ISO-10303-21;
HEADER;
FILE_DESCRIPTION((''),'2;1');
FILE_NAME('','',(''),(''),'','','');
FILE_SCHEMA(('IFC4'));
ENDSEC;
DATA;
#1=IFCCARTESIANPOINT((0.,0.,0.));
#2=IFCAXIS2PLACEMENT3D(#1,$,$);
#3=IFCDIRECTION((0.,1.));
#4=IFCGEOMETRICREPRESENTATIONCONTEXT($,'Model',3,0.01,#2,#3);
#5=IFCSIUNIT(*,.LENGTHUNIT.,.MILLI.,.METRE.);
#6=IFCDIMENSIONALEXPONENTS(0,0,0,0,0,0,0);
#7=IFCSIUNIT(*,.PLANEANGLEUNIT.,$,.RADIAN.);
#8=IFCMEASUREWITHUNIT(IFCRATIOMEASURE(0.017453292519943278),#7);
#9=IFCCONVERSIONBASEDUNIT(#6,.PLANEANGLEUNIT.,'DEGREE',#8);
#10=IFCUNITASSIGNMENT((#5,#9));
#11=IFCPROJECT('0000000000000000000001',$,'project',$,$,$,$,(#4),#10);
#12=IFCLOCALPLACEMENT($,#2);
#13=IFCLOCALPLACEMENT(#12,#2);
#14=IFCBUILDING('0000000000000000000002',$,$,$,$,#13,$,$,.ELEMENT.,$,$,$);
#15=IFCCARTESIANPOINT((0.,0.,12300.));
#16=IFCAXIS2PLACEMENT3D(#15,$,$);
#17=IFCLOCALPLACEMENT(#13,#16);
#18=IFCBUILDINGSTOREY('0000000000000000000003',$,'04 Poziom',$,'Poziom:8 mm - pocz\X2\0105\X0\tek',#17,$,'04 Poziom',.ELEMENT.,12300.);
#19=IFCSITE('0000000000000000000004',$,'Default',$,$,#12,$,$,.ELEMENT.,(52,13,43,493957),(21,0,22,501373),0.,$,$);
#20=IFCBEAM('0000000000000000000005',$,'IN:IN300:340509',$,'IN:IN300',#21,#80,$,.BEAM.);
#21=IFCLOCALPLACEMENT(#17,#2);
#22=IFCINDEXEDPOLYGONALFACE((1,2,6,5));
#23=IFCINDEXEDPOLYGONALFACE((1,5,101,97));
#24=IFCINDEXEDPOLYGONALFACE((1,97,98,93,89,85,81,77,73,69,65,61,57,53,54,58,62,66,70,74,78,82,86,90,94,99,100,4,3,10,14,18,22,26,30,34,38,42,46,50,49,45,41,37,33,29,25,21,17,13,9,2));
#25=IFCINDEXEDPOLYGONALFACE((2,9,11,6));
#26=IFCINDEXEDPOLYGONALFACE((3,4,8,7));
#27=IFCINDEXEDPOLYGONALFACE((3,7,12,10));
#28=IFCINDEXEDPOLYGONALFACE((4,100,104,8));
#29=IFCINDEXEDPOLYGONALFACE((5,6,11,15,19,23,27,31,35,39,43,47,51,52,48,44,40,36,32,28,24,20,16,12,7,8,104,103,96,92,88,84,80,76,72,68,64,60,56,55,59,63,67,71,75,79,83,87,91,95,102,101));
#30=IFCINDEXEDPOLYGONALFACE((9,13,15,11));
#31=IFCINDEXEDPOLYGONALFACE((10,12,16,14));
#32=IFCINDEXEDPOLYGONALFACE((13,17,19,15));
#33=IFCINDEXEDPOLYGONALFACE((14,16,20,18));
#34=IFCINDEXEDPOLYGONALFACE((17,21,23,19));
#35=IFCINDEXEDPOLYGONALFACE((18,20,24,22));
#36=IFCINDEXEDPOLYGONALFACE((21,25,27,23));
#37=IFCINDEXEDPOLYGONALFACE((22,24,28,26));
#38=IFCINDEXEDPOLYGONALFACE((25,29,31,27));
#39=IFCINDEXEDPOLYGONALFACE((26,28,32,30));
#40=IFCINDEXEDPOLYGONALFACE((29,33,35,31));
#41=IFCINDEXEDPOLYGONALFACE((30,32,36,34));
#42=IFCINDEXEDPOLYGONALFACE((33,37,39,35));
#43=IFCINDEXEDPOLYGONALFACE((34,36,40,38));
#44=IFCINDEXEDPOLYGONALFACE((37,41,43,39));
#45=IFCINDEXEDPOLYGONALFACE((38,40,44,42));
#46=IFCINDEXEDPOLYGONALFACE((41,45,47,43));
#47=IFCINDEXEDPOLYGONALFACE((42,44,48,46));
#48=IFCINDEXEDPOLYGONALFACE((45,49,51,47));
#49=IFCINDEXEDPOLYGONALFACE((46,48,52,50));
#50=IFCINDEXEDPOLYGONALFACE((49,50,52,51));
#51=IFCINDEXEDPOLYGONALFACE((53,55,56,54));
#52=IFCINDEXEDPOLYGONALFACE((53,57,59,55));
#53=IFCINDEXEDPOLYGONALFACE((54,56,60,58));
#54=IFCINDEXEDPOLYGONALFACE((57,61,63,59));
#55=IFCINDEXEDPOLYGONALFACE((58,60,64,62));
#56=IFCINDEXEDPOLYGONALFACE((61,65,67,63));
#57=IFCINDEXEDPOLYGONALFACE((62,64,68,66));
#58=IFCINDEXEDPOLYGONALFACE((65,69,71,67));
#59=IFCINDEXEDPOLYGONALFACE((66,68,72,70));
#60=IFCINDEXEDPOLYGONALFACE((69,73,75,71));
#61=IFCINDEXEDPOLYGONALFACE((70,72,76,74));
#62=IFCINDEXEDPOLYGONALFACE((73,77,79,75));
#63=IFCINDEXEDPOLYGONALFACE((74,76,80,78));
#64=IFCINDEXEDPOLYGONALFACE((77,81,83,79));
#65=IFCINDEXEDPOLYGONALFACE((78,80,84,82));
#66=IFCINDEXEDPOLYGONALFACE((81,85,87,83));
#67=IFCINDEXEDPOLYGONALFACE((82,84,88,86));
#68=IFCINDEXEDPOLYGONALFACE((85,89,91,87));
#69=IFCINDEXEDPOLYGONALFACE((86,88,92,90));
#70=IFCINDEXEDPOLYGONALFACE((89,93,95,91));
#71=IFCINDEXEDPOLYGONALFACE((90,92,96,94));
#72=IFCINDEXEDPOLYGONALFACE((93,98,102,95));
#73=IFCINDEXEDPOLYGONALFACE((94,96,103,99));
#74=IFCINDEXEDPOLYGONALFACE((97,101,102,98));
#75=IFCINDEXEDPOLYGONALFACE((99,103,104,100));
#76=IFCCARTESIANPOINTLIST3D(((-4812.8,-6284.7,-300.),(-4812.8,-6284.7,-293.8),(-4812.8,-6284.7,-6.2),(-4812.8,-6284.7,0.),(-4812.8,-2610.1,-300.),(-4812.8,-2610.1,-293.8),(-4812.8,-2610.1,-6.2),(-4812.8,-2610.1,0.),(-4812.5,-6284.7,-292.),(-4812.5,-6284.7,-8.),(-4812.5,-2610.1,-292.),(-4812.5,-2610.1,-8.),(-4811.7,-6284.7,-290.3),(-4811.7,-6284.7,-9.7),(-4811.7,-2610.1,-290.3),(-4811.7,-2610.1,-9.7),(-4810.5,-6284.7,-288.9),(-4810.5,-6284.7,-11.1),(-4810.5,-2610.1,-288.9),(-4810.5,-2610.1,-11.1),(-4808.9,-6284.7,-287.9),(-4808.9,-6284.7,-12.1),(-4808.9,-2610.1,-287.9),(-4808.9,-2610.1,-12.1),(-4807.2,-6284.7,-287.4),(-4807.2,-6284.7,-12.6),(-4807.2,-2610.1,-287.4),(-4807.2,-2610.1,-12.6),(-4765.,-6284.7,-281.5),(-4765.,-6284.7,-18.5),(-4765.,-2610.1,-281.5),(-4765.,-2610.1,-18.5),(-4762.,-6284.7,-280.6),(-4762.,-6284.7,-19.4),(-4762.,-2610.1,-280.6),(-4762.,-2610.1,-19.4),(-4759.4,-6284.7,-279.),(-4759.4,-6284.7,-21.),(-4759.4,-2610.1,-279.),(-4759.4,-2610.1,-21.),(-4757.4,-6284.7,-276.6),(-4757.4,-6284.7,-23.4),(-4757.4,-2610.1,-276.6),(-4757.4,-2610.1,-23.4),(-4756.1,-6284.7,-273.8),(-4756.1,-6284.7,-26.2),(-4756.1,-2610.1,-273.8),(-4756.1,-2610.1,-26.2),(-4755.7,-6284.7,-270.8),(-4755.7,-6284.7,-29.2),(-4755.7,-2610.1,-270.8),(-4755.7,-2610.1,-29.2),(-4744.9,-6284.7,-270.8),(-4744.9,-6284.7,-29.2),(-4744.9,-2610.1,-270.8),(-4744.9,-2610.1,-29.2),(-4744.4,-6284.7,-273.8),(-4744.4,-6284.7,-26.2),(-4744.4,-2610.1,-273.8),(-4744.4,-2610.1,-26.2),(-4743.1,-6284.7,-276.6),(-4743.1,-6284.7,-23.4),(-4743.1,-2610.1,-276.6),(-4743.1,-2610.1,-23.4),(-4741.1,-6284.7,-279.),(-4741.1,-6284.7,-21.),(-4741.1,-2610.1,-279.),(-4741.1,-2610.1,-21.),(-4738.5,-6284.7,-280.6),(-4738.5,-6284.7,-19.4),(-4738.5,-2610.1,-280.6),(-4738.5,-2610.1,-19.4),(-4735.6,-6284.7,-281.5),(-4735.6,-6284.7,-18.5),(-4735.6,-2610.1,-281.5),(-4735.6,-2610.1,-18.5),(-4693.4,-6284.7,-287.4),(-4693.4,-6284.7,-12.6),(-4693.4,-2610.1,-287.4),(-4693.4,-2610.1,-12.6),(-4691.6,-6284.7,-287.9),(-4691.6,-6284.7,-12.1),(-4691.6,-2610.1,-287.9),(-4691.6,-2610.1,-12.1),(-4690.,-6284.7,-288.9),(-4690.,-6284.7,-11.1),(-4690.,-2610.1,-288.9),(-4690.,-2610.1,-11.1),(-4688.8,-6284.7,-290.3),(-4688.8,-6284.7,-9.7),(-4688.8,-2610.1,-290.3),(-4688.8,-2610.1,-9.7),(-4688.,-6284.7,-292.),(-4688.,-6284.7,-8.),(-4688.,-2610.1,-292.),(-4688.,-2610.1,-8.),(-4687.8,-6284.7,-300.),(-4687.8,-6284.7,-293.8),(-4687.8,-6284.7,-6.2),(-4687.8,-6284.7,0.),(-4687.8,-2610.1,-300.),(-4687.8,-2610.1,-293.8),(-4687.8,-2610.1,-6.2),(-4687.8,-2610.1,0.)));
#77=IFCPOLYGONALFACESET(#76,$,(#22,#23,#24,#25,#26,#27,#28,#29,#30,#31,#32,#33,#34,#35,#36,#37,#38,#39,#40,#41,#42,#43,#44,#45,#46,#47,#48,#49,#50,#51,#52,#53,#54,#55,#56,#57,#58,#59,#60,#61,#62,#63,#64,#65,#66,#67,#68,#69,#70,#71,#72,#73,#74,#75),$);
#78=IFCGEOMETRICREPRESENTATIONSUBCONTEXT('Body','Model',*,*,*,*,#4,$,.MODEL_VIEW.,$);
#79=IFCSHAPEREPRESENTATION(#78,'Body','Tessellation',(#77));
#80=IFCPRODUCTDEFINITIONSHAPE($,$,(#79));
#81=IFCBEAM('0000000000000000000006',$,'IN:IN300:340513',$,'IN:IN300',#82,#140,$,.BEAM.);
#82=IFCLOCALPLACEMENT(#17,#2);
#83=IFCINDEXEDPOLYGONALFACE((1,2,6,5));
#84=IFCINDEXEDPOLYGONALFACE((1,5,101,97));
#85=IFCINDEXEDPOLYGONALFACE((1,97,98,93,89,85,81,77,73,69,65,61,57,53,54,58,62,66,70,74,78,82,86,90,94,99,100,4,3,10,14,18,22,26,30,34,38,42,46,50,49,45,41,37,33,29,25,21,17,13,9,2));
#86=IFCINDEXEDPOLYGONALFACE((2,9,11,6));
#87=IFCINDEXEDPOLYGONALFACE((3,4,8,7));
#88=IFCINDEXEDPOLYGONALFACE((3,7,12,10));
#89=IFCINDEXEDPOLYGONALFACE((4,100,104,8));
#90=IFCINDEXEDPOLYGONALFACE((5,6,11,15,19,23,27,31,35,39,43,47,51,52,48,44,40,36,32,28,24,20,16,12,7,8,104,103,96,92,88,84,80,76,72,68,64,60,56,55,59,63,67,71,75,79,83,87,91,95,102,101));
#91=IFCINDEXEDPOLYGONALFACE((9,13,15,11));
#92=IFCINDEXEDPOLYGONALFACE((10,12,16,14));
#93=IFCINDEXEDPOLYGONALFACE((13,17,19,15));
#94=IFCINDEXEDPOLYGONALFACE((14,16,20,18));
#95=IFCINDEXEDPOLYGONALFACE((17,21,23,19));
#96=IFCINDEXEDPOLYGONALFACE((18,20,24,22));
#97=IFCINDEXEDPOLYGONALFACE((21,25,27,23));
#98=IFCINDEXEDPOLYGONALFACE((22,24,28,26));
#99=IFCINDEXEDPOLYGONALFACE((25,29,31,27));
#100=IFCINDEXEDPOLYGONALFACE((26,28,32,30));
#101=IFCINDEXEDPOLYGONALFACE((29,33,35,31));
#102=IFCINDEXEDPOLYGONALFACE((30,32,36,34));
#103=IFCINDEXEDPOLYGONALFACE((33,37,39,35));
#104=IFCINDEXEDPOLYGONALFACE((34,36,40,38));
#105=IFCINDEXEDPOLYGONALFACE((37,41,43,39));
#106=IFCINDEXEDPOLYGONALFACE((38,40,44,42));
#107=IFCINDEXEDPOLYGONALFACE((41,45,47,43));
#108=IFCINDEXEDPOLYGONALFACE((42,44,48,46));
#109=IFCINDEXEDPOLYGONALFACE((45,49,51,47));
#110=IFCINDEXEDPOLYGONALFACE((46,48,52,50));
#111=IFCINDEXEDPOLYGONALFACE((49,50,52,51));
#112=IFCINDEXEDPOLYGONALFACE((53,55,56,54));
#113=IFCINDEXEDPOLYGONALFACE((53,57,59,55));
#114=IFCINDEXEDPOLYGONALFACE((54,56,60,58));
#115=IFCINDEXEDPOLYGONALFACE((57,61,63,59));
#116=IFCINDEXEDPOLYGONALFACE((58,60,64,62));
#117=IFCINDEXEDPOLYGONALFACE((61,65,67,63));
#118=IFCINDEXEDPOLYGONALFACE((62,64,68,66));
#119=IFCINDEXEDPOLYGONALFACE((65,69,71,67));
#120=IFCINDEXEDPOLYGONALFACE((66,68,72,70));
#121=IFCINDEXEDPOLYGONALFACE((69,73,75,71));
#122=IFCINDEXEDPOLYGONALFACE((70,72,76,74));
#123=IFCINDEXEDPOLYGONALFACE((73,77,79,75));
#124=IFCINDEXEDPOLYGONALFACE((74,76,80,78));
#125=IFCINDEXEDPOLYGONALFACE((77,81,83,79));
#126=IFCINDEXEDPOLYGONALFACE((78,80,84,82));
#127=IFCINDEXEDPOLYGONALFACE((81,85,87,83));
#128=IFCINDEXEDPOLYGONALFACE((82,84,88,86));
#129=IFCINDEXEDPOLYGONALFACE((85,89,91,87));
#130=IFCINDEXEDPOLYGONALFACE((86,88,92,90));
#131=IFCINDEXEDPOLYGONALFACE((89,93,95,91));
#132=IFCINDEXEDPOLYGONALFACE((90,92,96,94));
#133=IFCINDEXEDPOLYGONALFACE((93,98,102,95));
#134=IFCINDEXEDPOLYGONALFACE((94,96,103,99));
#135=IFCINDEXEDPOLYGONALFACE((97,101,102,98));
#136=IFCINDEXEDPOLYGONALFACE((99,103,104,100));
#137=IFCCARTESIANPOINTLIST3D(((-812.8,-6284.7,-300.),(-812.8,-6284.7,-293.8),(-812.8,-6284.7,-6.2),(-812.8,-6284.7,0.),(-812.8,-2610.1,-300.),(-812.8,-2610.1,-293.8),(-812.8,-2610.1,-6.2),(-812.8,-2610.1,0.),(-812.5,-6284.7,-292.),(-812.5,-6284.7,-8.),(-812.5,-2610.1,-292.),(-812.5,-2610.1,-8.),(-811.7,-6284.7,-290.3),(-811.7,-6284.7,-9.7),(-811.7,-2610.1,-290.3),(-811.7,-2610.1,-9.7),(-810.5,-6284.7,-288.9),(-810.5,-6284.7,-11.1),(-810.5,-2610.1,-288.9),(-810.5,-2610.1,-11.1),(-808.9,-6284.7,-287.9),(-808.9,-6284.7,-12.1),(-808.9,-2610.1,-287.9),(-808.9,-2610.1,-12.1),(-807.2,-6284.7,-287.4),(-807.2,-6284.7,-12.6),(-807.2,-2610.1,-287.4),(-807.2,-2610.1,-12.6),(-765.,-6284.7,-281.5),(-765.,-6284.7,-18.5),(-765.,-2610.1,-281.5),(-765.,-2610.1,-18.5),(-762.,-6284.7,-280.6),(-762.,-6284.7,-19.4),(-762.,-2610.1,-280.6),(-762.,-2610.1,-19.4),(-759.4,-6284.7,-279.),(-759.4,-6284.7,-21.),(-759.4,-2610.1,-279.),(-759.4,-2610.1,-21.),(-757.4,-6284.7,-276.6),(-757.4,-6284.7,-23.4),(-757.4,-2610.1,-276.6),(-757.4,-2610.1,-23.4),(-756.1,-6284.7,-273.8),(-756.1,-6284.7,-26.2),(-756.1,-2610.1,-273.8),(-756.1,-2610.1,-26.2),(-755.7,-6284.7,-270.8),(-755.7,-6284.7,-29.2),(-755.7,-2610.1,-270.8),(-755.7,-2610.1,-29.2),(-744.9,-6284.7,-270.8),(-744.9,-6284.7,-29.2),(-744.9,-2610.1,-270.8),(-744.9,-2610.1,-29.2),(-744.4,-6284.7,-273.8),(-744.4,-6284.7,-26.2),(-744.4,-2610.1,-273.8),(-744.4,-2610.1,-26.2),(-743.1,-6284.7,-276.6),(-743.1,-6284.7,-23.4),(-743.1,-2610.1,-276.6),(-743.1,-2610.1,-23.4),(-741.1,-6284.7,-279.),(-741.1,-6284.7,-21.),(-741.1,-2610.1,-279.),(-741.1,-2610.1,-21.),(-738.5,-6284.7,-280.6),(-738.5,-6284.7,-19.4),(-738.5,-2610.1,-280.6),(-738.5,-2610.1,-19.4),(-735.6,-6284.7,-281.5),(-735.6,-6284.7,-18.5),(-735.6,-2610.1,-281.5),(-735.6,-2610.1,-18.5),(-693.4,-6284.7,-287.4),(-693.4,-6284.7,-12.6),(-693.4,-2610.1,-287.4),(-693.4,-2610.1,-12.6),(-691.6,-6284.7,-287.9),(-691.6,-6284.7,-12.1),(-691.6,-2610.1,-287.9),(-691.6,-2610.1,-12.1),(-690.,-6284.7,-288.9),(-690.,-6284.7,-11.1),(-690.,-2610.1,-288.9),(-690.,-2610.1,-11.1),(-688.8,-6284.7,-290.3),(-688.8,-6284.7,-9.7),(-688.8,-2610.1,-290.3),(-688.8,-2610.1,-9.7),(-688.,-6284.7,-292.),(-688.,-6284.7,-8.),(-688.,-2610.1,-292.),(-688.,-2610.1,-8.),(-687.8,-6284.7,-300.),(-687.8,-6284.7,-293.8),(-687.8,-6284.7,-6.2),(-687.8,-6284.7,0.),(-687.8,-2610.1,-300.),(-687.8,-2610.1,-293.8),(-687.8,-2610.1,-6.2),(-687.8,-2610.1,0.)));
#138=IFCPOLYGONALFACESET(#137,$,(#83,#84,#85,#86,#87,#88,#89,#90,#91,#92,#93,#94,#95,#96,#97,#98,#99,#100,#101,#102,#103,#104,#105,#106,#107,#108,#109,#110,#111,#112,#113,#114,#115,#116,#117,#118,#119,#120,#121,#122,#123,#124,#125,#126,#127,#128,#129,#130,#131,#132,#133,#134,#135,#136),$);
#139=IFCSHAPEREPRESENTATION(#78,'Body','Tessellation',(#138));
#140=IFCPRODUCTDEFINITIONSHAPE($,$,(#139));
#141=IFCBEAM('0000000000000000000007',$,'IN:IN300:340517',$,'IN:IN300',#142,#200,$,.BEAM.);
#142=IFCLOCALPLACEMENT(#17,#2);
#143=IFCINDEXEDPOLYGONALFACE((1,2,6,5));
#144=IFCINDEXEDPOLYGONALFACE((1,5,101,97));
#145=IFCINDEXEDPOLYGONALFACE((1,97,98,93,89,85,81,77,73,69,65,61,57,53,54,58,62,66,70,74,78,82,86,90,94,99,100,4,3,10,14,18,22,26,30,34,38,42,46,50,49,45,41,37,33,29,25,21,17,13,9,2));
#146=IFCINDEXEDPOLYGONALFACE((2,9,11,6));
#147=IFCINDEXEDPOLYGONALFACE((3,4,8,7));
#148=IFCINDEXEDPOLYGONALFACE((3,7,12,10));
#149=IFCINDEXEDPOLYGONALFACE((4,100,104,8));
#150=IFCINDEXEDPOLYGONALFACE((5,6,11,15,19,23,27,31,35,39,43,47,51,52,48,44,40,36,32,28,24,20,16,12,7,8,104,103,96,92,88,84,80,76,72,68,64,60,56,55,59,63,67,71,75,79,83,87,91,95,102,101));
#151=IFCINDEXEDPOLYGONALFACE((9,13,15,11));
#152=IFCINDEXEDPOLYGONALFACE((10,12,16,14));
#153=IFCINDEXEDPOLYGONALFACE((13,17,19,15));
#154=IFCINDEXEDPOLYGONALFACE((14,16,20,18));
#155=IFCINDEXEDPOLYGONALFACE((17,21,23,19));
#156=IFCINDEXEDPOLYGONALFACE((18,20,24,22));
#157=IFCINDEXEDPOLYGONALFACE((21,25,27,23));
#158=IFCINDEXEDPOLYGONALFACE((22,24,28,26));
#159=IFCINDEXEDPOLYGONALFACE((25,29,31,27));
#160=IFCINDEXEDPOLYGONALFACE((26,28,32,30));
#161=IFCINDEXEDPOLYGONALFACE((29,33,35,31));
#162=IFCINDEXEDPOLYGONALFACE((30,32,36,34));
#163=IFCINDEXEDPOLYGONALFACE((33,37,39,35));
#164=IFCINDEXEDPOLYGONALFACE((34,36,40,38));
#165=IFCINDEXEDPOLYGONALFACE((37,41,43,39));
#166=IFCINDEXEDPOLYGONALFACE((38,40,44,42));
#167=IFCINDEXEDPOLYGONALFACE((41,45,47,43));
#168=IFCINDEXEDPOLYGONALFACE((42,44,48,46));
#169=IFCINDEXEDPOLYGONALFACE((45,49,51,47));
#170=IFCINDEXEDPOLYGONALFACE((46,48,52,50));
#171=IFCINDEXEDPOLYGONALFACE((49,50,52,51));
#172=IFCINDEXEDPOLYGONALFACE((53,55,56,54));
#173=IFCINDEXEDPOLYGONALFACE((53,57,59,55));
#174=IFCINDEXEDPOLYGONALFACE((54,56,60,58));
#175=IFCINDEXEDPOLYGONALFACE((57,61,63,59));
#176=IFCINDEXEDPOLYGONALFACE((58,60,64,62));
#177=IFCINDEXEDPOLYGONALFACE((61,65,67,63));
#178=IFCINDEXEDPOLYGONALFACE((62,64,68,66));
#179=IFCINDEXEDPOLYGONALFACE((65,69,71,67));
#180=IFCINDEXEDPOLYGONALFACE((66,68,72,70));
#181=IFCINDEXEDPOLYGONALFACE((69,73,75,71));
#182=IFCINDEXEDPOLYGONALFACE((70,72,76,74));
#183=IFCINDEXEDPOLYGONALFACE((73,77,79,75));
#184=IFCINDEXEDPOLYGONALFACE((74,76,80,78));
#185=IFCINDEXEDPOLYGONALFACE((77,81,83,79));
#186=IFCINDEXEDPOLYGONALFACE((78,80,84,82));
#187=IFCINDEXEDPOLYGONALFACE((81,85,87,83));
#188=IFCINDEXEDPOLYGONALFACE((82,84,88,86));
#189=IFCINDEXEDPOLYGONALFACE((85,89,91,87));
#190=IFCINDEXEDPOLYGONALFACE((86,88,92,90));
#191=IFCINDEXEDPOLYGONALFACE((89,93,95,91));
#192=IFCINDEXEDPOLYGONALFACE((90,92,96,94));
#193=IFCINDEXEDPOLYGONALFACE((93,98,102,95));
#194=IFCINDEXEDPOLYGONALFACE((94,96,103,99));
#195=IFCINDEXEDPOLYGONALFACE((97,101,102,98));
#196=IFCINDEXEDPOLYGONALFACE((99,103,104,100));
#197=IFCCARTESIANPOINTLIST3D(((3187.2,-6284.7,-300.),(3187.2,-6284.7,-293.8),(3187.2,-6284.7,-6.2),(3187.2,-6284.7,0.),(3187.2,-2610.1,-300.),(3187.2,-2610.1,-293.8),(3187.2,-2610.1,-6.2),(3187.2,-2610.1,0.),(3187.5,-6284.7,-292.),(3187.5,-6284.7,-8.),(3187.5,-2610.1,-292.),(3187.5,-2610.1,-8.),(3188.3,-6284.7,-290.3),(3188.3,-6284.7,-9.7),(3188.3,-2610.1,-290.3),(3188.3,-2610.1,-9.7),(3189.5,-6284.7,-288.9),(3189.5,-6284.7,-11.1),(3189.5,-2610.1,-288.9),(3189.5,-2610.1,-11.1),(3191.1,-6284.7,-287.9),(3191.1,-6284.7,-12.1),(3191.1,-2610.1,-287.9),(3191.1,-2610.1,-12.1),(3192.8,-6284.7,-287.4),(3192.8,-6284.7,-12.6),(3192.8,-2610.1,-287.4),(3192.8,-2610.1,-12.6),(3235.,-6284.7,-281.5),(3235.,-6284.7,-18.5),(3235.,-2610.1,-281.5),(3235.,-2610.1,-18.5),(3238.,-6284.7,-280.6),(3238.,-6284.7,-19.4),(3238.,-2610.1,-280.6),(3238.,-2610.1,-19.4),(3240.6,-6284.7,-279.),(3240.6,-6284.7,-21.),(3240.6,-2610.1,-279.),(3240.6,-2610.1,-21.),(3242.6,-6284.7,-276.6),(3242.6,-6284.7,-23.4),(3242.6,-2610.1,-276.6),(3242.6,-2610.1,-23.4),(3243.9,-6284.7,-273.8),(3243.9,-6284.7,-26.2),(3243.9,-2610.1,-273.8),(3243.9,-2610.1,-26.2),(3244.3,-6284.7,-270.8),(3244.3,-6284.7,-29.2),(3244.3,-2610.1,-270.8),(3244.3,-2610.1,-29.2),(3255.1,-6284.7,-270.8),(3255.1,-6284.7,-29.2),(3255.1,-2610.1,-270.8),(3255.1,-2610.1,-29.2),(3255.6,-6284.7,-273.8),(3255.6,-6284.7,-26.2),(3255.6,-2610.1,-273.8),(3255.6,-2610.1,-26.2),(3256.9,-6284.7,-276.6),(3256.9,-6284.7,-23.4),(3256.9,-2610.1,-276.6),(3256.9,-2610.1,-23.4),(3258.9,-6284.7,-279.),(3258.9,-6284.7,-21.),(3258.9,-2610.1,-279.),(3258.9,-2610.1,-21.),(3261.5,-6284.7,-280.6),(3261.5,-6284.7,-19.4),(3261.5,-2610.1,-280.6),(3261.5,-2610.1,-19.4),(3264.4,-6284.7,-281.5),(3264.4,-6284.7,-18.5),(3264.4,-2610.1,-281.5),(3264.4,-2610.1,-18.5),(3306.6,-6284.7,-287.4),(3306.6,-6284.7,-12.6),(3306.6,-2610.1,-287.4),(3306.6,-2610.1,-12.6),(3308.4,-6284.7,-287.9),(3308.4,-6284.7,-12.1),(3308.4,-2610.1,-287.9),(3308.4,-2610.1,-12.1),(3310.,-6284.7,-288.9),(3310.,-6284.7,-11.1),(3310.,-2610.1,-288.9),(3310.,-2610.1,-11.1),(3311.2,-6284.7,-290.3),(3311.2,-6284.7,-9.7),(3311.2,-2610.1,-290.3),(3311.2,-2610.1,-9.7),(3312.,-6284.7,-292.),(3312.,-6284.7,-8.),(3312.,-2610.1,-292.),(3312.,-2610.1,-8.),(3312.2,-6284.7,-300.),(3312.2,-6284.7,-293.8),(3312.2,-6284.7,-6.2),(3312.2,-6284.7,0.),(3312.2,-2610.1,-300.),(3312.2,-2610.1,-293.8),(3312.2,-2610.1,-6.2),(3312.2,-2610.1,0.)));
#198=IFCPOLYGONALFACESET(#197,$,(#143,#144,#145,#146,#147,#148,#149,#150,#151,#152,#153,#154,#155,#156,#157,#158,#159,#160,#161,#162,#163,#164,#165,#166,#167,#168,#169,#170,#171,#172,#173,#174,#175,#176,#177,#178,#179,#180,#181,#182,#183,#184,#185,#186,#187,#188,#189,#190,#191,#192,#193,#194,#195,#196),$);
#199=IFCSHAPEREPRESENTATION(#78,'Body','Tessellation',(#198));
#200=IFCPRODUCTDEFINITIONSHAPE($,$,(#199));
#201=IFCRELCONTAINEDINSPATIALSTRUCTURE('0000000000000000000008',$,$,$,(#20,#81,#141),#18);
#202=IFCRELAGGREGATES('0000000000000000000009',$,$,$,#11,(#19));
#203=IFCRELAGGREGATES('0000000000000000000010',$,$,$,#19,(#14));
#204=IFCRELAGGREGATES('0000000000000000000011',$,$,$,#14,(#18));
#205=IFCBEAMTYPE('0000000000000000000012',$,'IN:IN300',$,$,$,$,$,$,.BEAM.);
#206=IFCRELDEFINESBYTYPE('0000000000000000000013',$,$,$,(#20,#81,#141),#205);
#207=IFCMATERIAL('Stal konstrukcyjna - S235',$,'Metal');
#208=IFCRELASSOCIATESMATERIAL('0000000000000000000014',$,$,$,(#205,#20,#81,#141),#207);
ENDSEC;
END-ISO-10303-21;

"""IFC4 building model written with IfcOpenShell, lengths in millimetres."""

from ifc_helpers import new_model, entity, si_unit, converted_unit, direction, frame, origin, place, context, subcontext, project, spatial, line, arc, indexed_curve, outline, extrude, source, transform, mapped, material, type_object, type_shapes, element, save


model = new_model("IFC4")

# Units and contexts
model_context = context("Model", 3, precision=0.01, world=origin(), true_north=direction((0.0, 1.0)))
body_context = subcontext(model_context, "Body", "Model", "MODEL_VIEW")
ifc_project = project(units=[si_unit("LENGTHUNIT", "METRE", prefix="MILLI"), converted_unit("PLANEANGLEUNIT", "DEGREE", entity("IfcRatioMeasure", 0.017453292519943278), si_unit("PLANEANGLEUNIT", "RADIAN"), dimensions=[0, 0, 0, 0, 0, 0, 0])], contexts=[model_context])

# Site, building, storey
site_placement = place(None, origin())
site = spatial("IfcSite", under=ifc_project, at=site_placement, Name="Default", CompositionType="ELEMENT", RefLatitude=(52, 13, 43, 493957), RefLongitude=(21, 0, 22, 501373), RefElevation=0.0)
building_placement = place(site_placement, origin())
building = spatial("IfcBuilding", under=site, at=building_placement, CompositionType="ELEMENT")
storey_placement = place(building_placement, frame((0.0, 0.0, 12300.0)))
storey = spatial("IfcBuildingStorey", under=building, at=storey_placement, Name="04 Poziom", ObjectType="Poziom:8 mm - początek", LongName="04 Poziom", CompositionType="ELEMENT", Elevation=12300.0)

# Shared definitions
ifc_material = material(Name="Stal konstrukcyjna - S235", Category="Metal")

# Beams
beam_type_1 = type_object("IfcBeamType", Name="IN:IN300", PredefinedType="BEAM", material=ifc_material)
shared_shape_1 = source(origin(), body_context, "Body", "SweptSolid", [
    extrude(outline(indexed_curve([(143.8, -62.5), (150.0, -62.5), (150.0, 62.5), (143.8, 62.5), (139.6, 60.9), (137.4, 56.9), (131.5, 14.7), (127.9, 8.1), (120.8, 5.4), (-120.8, 5.4), (-127.9, 8.1), (-131.5, 14.7), (-137.4, 56.9), (-139.6, 60.9), (-143.8, 62.5), (-150.0, 62.5), (-150.0, -62.5), (-143.8, -62.5), (-139.6, -60.9), (-137.4, -56.9), (-131.5, -14.7), (-127.9, -8.1), (-120.8, -5.4), (120.8, -5.4), (127.9, -8.1), (131.5, -14.7), (137.4, -56.9), (139.6, -60.9)], segments=[line(1, 2, 3, 4), arc(4, 5, 6), line(6, 7), arc(7, 8, 9), line(9, 10), arc(10, 11, 12), line(12, 13), arc(13, 14, 15), line(15, 16, 17, 18), arc(18, 19, 20), line(20, 21), arc(21, 22, 23), line(23, 24), arc(24, 25, 26), line(26, 27), arc(27, 28, 1)], self_intersect=False)), frame((-1837.3, 0.0, 0.0), z_axis=(1.0, 0.0, 0.0), x_axis=(0.0, 0.0, -1.0)), (0.0, 0.0, 1.0), 3674.6),
])
type_shapes(beam_type_1, [shared_shape_1])
for number, where, z_axis, x_axis, name in (
    (1, (-4750.3, -4447.4, -150.0), (0.0, 0.0, 1.0), (0.0, -1.0, 0.0), "IN:IN300:340509"),
    (2, (-750.3, -4447.4, -150.0), (0.0, 0.0, 1.0), (0.0, -1.0, 0.0), "IN:IN300:340513"),
    (3, (3249.7, -4447.4, -150.0), (0.0, 0.0, 1.0), (0.0, -1.0, 0.0), "IN:IN300:340517"),
):
    element("IfcBeam", number, at=place(storey_placement, frame(where, z_axis=z_axis, x_axis=x_axis)), inside=storey, type_object=beam_type_1, material=ifc_material, Name=name, ObjectType="IN:IN300", PredefinedType="BEAM", context=body_context, shape_type="MappedRepresentation", body=[
        mapped(shared_shape_1, transform((0.0, 0.0, 0.0), scale=1.0)),
    ])

save(model, "model.ifc")
